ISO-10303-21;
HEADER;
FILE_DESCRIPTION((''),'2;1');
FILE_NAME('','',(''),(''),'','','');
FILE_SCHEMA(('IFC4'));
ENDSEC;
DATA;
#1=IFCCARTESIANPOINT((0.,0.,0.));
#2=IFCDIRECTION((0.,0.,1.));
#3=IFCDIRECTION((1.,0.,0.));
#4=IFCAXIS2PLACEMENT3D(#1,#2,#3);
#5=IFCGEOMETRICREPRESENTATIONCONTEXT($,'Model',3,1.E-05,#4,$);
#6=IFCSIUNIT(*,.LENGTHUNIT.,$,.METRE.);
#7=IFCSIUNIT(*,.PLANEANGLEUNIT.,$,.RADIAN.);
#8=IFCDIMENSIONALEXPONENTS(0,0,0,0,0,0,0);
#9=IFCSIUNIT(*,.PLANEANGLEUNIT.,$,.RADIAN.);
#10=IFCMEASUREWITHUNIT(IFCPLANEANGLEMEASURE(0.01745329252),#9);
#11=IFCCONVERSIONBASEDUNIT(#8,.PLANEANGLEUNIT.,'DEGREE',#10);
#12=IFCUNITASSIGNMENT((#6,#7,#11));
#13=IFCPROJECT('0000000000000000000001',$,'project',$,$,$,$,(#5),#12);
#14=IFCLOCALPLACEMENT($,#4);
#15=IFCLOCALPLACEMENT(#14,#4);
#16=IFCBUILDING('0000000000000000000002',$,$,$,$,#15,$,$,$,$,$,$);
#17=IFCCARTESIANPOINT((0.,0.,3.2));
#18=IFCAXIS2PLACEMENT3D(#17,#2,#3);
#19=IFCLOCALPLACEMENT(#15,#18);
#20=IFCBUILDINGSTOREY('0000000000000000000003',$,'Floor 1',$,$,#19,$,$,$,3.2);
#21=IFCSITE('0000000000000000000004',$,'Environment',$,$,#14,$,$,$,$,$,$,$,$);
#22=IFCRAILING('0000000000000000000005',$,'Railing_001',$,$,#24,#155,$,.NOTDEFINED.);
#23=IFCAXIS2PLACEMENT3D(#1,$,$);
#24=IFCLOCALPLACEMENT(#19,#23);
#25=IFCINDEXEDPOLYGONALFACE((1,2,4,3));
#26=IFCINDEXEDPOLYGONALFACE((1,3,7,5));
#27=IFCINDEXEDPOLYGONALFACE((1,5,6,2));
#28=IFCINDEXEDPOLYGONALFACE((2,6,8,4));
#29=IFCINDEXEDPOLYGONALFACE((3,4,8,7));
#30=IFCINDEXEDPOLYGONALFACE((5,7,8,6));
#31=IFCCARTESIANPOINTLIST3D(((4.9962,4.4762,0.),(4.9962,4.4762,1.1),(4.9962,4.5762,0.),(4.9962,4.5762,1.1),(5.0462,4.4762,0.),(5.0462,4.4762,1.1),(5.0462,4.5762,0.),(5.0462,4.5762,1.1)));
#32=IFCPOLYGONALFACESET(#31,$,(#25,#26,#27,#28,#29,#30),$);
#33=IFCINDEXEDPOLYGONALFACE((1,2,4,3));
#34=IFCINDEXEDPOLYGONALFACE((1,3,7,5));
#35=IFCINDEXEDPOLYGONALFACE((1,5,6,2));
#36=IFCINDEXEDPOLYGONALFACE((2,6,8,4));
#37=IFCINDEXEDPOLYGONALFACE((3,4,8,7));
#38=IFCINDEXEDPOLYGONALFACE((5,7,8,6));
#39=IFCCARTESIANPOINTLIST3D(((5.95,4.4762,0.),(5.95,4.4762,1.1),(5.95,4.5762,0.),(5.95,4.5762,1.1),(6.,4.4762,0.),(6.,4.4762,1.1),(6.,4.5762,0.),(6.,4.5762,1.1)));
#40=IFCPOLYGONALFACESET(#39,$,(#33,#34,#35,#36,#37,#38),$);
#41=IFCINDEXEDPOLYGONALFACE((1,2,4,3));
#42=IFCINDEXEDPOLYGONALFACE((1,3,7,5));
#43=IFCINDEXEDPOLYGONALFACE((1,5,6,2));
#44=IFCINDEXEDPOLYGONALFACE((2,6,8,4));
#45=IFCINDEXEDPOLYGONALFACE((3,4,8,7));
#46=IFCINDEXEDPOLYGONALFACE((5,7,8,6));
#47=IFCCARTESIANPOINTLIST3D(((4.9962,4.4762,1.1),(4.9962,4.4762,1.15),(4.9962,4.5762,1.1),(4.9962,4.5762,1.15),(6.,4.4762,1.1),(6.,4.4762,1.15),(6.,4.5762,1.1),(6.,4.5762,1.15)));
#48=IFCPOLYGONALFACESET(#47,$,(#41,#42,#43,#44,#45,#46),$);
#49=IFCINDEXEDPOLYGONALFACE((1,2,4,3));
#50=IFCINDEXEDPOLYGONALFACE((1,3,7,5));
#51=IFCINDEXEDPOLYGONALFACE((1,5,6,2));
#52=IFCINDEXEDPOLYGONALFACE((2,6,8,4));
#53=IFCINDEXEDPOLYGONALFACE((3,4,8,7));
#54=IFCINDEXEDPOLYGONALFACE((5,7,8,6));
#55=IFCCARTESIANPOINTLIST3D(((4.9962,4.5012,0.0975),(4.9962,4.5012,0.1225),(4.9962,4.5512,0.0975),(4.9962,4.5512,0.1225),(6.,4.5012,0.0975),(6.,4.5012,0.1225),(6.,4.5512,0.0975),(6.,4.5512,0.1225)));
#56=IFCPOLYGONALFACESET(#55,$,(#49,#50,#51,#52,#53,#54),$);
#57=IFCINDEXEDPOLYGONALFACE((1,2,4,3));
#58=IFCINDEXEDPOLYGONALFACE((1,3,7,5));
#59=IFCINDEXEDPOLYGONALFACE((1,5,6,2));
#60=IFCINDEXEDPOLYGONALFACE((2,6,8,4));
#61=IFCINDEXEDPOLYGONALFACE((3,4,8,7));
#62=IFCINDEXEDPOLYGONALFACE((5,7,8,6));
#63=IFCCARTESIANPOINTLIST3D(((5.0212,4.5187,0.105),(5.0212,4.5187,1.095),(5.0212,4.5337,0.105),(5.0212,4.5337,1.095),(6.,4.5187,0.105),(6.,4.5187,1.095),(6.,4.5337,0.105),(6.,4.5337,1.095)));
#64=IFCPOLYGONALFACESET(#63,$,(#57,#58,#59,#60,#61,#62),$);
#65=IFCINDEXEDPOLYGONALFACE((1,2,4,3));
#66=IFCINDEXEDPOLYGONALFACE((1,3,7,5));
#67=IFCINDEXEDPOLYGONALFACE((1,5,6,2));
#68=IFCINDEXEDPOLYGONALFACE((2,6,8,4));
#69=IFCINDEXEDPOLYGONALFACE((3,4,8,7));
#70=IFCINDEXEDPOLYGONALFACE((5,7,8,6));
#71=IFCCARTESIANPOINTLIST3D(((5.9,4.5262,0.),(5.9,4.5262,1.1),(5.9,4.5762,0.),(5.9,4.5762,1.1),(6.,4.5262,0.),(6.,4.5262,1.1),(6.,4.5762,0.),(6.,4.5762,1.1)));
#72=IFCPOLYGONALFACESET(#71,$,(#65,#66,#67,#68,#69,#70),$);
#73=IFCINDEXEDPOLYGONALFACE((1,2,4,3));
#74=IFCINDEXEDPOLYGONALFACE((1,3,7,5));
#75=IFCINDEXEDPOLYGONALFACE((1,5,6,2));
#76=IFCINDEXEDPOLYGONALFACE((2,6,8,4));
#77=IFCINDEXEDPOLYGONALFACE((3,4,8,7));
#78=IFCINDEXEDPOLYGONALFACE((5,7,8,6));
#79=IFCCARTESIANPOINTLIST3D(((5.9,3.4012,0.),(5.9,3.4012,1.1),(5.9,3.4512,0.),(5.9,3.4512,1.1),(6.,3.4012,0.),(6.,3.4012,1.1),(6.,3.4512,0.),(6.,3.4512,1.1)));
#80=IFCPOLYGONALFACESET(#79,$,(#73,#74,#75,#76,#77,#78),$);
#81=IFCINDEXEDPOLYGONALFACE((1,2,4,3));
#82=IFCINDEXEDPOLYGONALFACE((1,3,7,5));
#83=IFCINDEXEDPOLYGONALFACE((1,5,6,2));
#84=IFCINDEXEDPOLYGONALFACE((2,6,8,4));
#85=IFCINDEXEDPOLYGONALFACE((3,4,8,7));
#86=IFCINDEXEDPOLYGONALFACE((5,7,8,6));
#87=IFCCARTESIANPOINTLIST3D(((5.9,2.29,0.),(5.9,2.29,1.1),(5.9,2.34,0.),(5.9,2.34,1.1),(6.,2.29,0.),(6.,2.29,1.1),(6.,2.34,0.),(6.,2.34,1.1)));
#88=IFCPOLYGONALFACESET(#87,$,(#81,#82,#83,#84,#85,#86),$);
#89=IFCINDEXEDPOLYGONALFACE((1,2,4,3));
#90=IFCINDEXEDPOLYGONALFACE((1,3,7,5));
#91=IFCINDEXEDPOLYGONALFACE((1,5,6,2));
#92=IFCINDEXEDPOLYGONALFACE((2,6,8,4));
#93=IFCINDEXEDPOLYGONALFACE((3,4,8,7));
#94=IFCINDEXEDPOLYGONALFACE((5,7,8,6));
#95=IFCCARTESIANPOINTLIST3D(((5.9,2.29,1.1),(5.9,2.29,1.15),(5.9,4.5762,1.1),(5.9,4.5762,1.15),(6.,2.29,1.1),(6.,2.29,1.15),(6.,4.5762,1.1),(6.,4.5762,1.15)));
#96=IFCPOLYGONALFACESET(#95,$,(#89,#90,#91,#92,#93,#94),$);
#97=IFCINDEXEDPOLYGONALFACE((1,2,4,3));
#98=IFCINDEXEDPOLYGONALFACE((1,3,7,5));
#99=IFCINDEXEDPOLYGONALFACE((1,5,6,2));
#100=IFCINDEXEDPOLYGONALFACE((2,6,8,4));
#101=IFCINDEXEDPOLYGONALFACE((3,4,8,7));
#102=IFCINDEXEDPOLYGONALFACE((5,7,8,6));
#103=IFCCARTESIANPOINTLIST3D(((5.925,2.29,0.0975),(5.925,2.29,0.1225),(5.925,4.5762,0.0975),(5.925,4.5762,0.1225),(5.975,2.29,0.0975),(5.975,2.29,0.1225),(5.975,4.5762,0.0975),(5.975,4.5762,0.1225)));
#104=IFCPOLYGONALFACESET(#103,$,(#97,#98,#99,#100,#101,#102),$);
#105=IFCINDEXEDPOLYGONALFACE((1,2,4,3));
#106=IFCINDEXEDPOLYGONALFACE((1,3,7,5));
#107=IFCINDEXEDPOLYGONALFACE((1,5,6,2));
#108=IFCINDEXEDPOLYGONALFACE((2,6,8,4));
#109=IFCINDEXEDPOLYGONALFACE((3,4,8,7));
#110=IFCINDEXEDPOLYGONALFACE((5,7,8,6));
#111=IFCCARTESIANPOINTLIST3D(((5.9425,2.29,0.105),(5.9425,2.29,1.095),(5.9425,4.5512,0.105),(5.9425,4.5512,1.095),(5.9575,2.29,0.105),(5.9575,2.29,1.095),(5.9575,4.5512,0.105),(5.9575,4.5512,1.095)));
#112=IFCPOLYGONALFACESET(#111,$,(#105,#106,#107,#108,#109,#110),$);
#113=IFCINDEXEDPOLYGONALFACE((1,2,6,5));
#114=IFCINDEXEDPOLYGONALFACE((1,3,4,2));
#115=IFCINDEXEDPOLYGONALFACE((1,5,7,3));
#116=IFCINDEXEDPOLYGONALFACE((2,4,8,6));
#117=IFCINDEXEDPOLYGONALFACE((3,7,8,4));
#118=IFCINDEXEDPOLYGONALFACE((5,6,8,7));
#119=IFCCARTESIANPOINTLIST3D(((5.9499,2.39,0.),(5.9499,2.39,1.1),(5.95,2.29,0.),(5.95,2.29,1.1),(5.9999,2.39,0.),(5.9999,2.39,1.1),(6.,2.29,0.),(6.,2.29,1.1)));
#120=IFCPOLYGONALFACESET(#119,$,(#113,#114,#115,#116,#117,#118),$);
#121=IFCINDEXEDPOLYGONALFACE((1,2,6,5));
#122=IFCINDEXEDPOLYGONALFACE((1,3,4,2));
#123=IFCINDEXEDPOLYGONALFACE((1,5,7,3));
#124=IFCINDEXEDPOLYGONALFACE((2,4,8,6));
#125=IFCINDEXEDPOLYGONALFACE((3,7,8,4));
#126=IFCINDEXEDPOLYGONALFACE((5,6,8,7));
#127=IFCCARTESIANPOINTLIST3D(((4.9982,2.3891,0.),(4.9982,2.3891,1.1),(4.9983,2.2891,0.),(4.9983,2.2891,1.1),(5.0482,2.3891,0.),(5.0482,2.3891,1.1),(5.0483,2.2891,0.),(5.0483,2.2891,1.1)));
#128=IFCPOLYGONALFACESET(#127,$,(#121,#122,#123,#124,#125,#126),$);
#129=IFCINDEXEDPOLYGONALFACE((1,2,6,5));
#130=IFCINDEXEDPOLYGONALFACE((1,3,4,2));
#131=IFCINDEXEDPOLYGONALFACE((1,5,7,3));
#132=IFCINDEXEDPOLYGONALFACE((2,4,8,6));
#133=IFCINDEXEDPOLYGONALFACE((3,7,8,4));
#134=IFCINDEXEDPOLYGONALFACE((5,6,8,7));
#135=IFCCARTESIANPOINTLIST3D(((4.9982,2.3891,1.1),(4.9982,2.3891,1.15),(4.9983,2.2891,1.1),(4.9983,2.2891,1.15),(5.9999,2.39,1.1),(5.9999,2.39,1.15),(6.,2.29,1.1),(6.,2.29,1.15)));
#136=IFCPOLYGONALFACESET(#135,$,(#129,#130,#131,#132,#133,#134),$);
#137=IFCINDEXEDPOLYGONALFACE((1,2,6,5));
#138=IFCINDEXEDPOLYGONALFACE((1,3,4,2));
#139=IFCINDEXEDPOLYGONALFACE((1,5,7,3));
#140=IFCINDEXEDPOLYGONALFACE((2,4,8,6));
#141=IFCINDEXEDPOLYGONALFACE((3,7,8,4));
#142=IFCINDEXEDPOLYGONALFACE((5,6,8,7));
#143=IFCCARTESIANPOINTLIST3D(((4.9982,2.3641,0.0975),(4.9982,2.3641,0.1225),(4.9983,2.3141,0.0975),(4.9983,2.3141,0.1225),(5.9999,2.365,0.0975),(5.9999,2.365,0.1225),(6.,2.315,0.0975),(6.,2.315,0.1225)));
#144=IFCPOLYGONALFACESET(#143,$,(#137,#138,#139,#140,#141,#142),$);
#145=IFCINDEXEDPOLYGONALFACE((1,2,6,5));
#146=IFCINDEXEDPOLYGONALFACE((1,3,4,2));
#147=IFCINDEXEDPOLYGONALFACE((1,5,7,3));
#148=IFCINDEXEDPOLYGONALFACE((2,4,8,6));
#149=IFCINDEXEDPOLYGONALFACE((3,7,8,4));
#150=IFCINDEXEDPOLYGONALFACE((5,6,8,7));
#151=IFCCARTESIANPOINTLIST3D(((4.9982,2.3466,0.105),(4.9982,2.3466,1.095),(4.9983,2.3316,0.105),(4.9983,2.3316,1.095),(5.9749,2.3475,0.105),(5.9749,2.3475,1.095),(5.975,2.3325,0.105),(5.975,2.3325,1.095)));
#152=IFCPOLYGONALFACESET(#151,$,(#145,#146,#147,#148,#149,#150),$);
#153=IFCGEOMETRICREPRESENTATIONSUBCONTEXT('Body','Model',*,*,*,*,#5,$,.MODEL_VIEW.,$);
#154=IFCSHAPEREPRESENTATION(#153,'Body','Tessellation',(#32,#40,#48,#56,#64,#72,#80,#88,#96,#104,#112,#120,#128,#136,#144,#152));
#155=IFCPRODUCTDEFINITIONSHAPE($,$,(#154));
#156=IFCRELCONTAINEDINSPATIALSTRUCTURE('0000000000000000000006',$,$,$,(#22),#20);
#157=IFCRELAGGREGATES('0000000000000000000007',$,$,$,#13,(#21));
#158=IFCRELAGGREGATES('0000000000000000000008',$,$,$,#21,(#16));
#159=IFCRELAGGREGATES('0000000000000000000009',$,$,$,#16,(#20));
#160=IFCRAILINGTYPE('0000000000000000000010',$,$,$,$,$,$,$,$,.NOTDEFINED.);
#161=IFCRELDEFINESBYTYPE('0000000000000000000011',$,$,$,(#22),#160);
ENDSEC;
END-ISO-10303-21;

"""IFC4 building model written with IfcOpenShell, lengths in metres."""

from ifc_helpers import new_model, entity, si_unit, converted_unit, frame, origin_with_axes, place, context, subcontext, project, spatial, polyline, outline, extrude, type_object, element, save


model = new_model("IFC4")

# Units and contexts
model_context = context("Model", 3, precision=1e-05, world=origin_with_axes())
body_context = subcontext(model_context, "Body", "Model", "MODEL_VIEW")
ifc_project = project(units=[si_unit("LENGTHUNIT", "METRE"), si_unit("PLANEANGLEUNIT", "RADIAN"), converted_unit("PLANEANGLEUNIT", "DEGREE", entity("IfcPlaneAngleMeasure", 0.01745329252), si_unit("PLANEANGLEUNIT", "RADIAN"), dimensions=[0, 0, 0, 0, 0, 0, 0])], contexts=[model_context])

# Site, building, storey
site_placement = place(None, origin_with_axes())
site = spatial("IfcSite", under=ifc_project, at=site_placement, Name="Environment")
building_placement = place(site_placement, origin_with_axes())
building = spatial("IfcBuilding", under=site, at=building_placement)
storey_placement = place(building_placement, frame((0.0, 0.0, 3.2), z_axis=(0.0, 0.0, 1.0), x_axis=(1.0, 0.0, 0.0)))
storey = spatial("IfcBuildingStorey", under=building, at=storey_placement, Name="Floor 1", Elevation=3.2)

# Railing
railing_type = type_object("IfcRailingType", PredefinedType="NOTDEFINED")
railing_1_placement = place(storey_placement, frame((0.0, 0.0, -3.2), z_axis=(0.0, 0.0, 1.0), x_axis=(1.0, 0.0, 0.0)))
element("IfcRailing", 1, at=railing_1_placement, inside=storey, type_object=railing_type, Name="Railing_001", PredefinedType="NOTDEFINED", context=body_context, shape_type="MappedRepresentation", body=[
    extrude(outline(polyline([(-0.025, -0.05), (0.025, -0.05), (0.025, 0.05), (-0.025, 0.05), (-0.025, -0.05)])), frame((5.0212, 4.5262, 3.2), z_axis=(0.0, 0.0, 1.0), x_axis=(1.0, 0.0, 0.0)), (0.0, 0.0, 1.0), 1.1),
    extrude(outline(polyline([(-0.025, -0.05), (0.025, -0.05), (0.025, 0.05), (-0.025, 0.05), (-0.025, -0.05)])), frame((5.975, 4.5262, 3.2), z_axis=(0.0, 0.0, 1.0), x_axis=(1.0, 0.0, 0.0)), (0.0, 0.0, 1.0), 1.1),
    extrude(outline(polyline([(-0.05, -0.025), (0.05, -0.025), (0.05, 0.025), (-0.05, 0.025), (-0.05, -0.025)])), frame((4.9962, 4.5262, 4.325), z_axis=(1.0, 0.0, 0.0), x_axis=(0.0, 1.0, 0.0)), (0.0, 0.0, 1.0), 1.0038),
    extrude(outline(polyline([(-0.025, -0.0125), (0.025, -0.0125), (0.025, 0.0125), (-0.025, 0.0125), (-0.025, -0.0125)])), frame((4.9962, 4.5262, 3.31), z_axis=(1.0, 0.0, 0.0), x_axis=(0.0, 1.0, 0.0)), (0.0, 0.0, 1.0), 1.0038),
    extrude(outline(polyline([(-0.0075, -0.495), (0.0075, -0.495), (0.0075, 0.495), (-0.0075, 0.495), (-0.0075, -0.495)])), frame((5.0212, 4.5262, 3.8), z_axis=(1.0, 0.0, 0.0), x_axis=(0.0, 1.0, 0.0)), (0.0, 0.0, 1.0), 0.9788),
    extrude(outline(polyline([(-0.025, -0.05), (0.025, -0.05), (0.025, 0.05), (-0.025, 0.05), (-0.025, -0.05)])), frame((5.95, 4.5512, 3.2), z_axis=(0.0, 0.0, 1.0), x_axis=(0.0, -1.0, 0.0)), (0.0, 0.0, 1.0), 1.1),
    extrude(outline(polyline([(-0.025, -0.05), (0.025, -0.05), (0.025, 0.05), (-0.025, 0.05), (-0.025, -0.05)])), frame((5.95, 3.4262, 3.2), z_axis=(0.0, 0.0, 1.0), x_axis=(0.0, -1.0, 0.0)), (0.0, 0.0, 1.0), 1.1),
    extrude(outline(polyline([(-0.025, -0.05), (0.025, -0.05), (0.025, 0.05), (-0.025, 0.05), (-0.025, -0.05)])), frame((5.95, 2.315, 3.2), z_axis=(0.0, 0.0, 1.0), x_axis=(0.0, -1.0, 0.0)), (0.0, 0.0, 1.0), 1.1),
    extrude(outline(polyline([(-0.05, -0.025), (0.05, -0.025), (0.05, 0.025), (-0.05, 0.025), (-0.05, -0.025)])), frame((5.95, 4.5762, 4.325), z_axis=(0.0, -1.0, 0.0), x_axis=(1.0, 0.0, 0.0)), (0.0, 0.0, 1.0), 2.2862),
    extrude(outline(polyline([(-0.025, -0.0125), (0.025, -0.0125), (0.025, 0.0125), (-0.025, 0.0125), (-0.025, -0.0125)])), frame((5.95, 4.5762, 3.31), z_axis=(0.0, -1.0, 0.0), x_axis=(1.0, 0.0, 0.0)), (0.0, 0.0, 1.0), 2.2862),
    extrude(outline(polyline([(-0.0075, -0.495), (0.0075, -0.495), (0.0075, 0.495), (-0.0075, 0.495), (-0.0075, -0.495)])), frame((5.95, 4.5512, 3.8), z_axis=(0.0, -1.0, 0.0), x_axis=(1.0, 0.0, 0.0)), (0.0, 0.0, 1.0), 2.2612),
    extrude(outline(polyline([(-0.025, -0.05), (0.025, -0.05), (0.025, 0.05), (-0.025, 0.05), (-0.025, -0.05)])), frame((5.975, 2.34, 3.2), z_axis=(0.0, 0.0, 1.0), x_axis=(-1.0, -0.000908, 0.0)), (0.0, 0.0, 1.0), 1.1),
    extrude(outline(polyline([(-0.025, -0.05), (0.025, -0.05), (0.025, 0.05), (-0.025, 0.05), (-0.025, -0.05)])), frame((5.0233, 2.3391, 3.2), z_axis=(0.0, 0.0, 1.0), x_axis=(-1.0, -0.000908, 0.0)), (0.0, 0.0, 1.0), 1.1),
    extrude(outline(polyline([(-0.05, -0.025), (0.05, -0.025), (0.05, 0.025), (-0.05, 0.025), (-0.05, -0.025)])), frame((6.0, 2.34, 4.325), z_axis=(-1.0, -0.000908, 0.0), x_axis=(0.000908, -1.0, 0.0)), (0.0, 0.0, 1.0), 1.0017),
    extrude(outline(polyline([(-0.025, -0.0125), (0.025, -0.0125), (0.025, 0.0125), (-0.025, 0.0125), (-0.025, -0.0125)])), frame((6.0, 2.34, 3.31), z_axis=(-1.0, -0.000908, 0.0), x_axis=(0.000908, -1.0, 0.0)), (0.0, 0.0, 1.0), 1.0017),
    extrude(outline(polyline([(-0.0075, -0.495), (0.0075, -0.495), (0.0075, 0.495), (-0.0075, 0.495), (-0.0075, -0.495)])), frame((5.975, 2.34, 3.8), z_axis=(-1.0, -0.000908, 0.0), x_axis=(0.000908, -1.0, 0.0)), (0.0, 0.0, 1.0), 0.9767),
])

save(model, "model.ifc")
